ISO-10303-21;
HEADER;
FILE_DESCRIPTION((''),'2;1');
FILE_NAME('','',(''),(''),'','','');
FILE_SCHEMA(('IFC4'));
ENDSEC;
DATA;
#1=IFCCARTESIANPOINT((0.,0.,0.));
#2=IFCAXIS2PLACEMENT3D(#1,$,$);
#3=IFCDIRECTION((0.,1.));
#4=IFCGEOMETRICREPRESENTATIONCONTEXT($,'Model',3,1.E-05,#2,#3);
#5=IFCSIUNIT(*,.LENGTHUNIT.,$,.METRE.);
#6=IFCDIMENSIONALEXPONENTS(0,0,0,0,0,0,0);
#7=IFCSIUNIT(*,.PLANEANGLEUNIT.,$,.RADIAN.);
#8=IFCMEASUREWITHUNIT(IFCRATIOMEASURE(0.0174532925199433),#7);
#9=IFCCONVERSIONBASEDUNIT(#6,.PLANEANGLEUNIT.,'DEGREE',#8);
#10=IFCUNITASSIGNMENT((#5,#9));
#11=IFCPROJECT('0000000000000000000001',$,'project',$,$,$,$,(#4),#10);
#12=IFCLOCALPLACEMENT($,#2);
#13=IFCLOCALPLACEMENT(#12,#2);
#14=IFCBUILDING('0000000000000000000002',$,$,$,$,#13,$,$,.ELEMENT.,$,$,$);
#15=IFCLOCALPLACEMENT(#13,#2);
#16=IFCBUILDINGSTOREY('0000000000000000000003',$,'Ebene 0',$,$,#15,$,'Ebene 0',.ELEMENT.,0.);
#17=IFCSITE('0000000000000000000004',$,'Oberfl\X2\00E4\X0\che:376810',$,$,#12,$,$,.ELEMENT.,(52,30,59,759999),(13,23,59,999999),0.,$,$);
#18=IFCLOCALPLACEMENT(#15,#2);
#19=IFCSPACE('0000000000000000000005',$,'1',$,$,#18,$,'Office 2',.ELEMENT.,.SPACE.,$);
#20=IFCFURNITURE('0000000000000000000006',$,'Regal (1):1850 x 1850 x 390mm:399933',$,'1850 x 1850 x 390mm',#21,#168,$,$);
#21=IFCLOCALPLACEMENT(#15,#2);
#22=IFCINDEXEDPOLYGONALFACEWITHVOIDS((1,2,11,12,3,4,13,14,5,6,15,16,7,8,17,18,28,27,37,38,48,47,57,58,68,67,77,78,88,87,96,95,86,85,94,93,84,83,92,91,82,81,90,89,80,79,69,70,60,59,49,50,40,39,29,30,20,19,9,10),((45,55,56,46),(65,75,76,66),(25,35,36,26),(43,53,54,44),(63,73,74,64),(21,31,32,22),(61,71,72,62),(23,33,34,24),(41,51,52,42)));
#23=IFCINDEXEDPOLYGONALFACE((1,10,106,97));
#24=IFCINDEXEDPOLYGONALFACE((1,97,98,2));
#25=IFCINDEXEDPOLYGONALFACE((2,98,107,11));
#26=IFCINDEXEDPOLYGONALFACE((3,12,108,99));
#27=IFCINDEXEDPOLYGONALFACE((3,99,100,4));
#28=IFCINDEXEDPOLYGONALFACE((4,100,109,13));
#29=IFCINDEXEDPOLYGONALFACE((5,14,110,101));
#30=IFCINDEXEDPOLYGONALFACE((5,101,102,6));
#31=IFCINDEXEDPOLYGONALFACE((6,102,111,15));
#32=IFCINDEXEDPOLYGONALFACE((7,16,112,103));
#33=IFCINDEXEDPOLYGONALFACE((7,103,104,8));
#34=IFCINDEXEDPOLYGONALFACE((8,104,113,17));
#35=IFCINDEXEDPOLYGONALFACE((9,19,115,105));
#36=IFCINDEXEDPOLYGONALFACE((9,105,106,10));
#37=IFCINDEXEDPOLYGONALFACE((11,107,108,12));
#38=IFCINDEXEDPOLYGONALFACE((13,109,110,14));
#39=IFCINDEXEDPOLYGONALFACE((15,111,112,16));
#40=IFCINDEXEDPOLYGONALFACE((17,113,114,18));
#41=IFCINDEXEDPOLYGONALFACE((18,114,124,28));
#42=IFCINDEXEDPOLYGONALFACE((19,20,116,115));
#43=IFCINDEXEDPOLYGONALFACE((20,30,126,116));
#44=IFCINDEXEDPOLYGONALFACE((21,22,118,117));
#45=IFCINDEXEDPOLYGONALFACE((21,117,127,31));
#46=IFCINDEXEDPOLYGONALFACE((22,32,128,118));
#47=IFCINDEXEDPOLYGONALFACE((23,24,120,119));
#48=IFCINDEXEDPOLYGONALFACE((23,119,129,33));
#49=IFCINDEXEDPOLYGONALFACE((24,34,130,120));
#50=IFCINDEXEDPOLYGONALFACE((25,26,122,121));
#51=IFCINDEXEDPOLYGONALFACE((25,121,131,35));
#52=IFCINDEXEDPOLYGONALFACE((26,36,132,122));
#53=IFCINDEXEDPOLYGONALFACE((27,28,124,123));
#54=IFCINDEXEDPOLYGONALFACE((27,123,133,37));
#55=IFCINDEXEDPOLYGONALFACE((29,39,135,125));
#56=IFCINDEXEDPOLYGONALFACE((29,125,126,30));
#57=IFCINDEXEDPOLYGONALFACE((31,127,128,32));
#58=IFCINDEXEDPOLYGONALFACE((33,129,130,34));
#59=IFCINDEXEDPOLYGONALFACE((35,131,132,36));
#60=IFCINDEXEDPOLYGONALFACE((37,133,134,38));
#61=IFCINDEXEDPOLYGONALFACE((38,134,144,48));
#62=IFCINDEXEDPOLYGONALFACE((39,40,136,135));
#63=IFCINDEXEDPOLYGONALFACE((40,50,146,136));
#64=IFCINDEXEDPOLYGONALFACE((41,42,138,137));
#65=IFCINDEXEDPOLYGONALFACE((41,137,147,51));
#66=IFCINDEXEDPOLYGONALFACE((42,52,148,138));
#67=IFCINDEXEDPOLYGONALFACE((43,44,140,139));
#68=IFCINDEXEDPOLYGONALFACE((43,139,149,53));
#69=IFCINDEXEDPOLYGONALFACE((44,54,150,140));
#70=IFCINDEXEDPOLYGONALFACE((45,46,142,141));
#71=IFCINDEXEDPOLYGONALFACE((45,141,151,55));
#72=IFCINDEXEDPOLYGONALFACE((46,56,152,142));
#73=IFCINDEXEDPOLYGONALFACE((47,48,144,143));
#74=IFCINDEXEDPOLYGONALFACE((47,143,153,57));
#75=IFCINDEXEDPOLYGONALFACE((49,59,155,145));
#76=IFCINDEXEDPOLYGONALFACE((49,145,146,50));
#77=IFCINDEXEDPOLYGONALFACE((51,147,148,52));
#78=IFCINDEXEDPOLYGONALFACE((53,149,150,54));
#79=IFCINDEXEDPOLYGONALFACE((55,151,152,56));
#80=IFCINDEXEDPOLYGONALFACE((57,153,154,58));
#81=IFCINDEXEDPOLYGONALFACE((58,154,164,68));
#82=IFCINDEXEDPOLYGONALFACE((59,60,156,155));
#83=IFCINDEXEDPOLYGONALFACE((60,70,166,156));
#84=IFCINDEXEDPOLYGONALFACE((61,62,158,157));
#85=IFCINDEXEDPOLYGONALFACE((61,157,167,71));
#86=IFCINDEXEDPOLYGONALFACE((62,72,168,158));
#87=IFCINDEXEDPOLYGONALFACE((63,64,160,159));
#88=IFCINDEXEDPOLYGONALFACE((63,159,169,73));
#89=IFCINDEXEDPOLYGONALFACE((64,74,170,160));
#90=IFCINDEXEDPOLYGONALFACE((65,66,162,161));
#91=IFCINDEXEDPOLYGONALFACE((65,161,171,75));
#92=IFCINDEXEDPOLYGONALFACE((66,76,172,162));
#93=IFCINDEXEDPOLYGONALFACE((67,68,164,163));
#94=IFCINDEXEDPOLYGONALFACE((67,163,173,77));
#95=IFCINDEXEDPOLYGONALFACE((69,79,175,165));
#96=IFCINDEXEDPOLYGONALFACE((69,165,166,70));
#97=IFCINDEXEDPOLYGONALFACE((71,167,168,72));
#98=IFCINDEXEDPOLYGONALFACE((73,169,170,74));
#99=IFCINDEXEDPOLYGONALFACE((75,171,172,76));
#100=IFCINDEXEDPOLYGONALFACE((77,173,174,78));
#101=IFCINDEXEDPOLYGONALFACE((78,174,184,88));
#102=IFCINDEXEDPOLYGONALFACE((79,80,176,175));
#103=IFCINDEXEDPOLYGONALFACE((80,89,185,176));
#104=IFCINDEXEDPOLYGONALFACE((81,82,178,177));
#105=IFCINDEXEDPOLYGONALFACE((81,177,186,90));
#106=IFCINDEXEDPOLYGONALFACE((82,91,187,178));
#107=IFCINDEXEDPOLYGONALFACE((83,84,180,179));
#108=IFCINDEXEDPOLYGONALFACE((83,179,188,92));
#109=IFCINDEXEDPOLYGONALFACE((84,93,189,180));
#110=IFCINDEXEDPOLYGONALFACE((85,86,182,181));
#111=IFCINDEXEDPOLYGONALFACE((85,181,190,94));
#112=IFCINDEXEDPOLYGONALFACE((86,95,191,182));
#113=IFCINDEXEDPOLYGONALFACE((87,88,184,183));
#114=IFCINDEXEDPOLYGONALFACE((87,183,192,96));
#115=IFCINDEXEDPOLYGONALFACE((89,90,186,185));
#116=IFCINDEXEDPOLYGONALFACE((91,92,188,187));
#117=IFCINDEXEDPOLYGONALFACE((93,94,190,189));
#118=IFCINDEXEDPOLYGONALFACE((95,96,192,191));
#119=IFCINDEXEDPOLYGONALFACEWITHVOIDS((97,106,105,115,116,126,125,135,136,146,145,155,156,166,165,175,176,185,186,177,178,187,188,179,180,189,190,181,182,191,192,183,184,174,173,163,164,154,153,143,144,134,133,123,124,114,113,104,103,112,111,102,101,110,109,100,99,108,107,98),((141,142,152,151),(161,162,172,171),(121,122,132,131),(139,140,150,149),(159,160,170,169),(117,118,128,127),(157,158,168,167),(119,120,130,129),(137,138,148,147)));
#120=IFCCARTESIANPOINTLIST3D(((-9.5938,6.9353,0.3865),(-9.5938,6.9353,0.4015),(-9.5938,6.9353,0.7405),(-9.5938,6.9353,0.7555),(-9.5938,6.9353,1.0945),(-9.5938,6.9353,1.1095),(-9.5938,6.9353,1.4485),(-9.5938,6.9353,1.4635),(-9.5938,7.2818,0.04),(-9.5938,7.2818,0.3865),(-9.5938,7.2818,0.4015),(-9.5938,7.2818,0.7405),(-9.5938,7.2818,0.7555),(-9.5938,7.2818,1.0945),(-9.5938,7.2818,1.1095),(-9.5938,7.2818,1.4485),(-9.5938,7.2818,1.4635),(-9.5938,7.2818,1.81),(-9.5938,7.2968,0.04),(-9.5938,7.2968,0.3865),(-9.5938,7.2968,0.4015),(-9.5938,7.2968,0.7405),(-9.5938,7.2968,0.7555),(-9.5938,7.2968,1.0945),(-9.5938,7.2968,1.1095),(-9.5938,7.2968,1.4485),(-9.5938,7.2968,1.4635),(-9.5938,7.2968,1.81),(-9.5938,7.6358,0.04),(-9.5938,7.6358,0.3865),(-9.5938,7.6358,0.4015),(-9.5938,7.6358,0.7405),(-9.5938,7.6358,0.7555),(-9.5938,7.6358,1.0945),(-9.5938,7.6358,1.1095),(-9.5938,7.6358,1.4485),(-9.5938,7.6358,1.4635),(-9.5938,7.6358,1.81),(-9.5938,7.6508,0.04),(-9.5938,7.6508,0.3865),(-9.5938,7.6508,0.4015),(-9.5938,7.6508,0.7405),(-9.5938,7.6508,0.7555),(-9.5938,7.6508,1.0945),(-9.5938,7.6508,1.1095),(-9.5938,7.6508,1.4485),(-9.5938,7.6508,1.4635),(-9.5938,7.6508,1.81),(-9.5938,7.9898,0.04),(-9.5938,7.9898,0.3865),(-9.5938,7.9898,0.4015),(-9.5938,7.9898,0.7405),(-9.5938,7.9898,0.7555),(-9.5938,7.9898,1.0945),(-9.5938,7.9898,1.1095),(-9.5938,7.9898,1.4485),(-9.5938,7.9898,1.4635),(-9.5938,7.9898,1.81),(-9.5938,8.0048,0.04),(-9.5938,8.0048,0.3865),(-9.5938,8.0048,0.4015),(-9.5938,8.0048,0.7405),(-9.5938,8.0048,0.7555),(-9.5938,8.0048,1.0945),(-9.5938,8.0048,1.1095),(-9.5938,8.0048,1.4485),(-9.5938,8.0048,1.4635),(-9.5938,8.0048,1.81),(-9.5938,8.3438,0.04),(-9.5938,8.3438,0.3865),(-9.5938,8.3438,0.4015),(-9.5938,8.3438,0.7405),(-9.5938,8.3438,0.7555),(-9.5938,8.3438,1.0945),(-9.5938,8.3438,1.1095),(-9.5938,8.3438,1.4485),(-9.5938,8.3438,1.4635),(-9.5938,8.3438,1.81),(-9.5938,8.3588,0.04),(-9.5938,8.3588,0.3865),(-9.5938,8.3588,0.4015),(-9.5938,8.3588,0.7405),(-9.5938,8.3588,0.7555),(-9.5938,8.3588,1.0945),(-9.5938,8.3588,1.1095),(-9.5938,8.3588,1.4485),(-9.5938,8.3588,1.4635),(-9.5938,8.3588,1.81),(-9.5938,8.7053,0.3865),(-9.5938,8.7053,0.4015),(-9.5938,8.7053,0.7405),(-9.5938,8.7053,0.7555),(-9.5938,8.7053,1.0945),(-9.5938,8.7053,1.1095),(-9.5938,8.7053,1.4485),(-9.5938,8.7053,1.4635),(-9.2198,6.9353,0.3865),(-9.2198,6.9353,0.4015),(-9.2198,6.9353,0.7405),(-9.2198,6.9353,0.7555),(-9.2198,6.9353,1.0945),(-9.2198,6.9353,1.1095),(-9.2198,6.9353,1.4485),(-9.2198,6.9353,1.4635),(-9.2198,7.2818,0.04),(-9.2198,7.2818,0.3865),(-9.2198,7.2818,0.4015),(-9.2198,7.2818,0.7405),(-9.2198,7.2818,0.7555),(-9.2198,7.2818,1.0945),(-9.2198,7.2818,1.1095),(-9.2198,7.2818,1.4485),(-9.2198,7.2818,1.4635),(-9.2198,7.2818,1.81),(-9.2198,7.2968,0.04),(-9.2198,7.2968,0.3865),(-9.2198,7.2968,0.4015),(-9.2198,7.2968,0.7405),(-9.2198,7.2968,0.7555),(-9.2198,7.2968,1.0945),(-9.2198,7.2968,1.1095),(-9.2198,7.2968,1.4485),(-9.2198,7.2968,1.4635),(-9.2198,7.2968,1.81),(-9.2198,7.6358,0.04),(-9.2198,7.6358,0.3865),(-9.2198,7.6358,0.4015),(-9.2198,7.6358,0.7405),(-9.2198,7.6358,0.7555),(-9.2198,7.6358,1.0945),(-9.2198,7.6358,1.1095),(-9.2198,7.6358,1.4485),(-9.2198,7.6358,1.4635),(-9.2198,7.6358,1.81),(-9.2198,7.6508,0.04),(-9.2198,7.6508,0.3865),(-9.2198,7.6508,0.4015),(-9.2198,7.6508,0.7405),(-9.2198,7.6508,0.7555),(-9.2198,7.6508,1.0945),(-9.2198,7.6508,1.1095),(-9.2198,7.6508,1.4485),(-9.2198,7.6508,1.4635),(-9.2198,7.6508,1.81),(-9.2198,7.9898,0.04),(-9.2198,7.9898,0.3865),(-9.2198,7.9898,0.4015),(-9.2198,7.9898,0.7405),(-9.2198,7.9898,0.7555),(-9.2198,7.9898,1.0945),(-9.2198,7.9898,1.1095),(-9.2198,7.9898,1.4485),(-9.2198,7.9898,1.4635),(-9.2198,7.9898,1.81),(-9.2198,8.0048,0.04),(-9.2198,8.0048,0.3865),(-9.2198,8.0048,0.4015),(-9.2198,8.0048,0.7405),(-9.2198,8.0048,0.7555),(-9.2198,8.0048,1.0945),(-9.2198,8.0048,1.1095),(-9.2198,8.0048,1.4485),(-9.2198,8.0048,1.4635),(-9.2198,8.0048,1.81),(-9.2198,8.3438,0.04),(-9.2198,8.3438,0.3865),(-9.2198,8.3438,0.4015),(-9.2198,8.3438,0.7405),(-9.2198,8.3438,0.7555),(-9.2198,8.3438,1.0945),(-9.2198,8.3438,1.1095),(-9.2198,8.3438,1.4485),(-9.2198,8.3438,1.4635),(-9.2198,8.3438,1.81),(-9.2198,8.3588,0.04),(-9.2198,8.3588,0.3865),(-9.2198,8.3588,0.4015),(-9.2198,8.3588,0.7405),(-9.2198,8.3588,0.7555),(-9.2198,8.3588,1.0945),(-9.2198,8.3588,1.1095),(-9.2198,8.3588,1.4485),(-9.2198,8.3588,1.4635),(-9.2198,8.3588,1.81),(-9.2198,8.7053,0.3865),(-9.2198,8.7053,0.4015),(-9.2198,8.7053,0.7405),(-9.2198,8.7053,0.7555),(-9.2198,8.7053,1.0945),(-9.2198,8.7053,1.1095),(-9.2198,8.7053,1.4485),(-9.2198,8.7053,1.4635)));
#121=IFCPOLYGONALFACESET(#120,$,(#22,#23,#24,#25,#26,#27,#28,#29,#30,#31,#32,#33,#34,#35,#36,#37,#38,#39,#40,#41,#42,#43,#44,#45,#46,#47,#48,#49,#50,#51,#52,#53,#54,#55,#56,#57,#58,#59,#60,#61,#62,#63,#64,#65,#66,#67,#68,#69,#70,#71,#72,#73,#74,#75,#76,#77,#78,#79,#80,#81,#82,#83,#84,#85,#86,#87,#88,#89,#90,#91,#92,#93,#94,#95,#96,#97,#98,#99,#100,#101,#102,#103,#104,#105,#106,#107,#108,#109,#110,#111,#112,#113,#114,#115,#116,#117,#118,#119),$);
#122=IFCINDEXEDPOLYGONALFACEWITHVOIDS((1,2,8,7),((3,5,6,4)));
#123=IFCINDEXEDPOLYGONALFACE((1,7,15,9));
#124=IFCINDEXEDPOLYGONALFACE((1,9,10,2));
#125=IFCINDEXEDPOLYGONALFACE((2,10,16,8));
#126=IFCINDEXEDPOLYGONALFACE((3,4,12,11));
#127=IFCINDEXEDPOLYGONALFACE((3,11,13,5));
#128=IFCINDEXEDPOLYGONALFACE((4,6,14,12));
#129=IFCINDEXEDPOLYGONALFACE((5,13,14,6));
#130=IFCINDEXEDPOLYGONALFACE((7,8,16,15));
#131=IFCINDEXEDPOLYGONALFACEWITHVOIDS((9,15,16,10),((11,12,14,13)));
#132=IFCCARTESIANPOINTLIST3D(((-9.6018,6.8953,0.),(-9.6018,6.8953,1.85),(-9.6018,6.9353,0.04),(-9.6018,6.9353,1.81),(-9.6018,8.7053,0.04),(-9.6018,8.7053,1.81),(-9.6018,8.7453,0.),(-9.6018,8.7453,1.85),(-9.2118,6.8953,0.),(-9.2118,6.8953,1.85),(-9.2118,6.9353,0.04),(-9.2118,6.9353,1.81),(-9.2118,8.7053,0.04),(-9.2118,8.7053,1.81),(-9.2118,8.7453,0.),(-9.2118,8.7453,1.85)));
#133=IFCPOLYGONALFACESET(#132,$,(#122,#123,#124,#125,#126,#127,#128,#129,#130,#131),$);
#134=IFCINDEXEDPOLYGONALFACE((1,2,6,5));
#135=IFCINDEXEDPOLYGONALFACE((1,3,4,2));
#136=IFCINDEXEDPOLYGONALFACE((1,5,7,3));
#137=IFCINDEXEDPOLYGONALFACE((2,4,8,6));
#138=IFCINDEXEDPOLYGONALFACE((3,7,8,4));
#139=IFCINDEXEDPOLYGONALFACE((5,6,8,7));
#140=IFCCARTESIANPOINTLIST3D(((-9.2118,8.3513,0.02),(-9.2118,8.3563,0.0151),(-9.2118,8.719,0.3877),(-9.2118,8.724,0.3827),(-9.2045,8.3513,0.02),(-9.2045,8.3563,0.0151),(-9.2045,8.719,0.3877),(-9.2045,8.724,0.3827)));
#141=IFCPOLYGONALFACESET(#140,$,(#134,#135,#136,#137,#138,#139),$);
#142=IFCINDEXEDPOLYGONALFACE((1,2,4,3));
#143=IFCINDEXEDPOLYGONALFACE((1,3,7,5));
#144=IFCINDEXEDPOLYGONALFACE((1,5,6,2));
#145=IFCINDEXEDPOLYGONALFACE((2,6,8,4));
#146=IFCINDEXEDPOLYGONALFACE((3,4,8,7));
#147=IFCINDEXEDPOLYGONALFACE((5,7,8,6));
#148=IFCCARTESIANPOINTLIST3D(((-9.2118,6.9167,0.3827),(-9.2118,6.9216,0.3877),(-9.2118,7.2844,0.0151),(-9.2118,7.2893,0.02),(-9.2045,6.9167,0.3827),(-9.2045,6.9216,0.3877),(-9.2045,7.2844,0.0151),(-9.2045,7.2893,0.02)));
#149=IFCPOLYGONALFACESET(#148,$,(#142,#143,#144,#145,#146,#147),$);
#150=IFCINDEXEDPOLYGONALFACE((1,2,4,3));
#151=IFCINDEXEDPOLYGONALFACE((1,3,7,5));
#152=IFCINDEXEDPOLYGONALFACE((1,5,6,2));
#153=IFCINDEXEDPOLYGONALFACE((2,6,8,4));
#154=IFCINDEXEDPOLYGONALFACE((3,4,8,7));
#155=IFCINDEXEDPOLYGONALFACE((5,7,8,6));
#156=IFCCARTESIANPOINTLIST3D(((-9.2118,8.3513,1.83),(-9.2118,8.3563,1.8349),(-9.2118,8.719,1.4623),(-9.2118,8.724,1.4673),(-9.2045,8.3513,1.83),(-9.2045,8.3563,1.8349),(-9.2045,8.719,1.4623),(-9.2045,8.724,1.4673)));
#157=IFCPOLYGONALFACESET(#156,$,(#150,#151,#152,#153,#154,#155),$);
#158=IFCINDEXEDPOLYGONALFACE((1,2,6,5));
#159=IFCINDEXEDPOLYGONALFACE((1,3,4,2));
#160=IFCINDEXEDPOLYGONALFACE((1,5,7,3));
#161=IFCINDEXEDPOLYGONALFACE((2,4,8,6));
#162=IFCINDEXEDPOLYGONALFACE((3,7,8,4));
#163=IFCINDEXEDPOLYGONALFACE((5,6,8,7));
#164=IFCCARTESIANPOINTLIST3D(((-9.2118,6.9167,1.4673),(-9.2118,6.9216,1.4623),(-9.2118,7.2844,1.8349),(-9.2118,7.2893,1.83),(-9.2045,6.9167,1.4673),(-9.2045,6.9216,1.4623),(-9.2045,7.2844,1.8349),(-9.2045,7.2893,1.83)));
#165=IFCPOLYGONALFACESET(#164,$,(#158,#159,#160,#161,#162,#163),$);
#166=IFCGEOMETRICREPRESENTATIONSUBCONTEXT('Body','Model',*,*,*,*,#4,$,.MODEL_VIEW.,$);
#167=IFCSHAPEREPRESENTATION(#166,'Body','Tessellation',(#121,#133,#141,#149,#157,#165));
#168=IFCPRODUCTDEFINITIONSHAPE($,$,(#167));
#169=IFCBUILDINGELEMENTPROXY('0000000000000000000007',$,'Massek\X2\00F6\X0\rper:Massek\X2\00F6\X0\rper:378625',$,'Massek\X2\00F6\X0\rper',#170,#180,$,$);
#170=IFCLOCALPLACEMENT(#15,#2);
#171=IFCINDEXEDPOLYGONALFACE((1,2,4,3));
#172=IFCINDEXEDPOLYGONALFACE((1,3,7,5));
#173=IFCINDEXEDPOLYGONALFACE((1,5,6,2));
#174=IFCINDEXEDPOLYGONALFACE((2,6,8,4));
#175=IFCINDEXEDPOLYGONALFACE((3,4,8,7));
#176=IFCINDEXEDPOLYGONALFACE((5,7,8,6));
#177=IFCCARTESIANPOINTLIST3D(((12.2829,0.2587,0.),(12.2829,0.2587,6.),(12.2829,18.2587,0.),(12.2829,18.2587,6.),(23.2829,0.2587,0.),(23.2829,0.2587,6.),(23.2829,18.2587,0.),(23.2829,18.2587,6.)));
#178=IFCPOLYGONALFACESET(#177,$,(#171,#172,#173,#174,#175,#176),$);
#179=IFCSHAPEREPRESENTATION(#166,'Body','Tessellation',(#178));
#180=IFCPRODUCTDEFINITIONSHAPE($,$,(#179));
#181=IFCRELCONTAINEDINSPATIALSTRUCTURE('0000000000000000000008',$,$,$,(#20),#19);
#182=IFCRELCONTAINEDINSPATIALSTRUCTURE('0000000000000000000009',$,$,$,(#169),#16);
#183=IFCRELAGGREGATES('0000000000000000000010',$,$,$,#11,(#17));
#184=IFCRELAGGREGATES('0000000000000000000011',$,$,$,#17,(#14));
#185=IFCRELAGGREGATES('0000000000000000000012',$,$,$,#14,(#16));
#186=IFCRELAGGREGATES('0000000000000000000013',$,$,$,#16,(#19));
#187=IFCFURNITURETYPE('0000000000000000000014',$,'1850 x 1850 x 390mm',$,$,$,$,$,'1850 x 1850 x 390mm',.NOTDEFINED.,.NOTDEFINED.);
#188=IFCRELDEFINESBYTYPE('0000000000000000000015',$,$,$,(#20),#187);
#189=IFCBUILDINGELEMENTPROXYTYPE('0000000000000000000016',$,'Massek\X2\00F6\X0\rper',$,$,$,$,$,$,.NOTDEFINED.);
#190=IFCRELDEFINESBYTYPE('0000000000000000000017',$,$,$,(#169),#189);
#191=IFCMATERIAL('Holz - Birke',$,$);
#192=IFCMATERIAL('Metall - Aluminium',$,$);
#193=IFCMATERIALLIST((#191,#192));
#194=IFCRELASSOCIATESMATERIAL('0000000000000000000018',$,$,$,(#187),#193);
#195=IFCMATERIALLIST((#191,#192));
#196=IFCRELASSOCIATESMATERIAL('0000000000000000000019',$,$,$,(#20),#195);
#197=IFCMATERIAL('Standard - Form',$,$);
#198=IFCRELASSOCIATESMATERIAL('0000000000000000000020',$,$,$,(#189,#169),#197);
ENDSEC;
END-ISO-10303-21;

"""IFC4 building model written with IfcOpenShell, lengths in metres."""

from ifc_helpers import new_model, entity, si_unit, converted_unit, direction, frame, frame_2d, origin, place, context, subcontext, project, spatial, polyline, rectangle, outline, extrude, source, transform, mapped, material, material_list, type_object, type_shapes, element, save


model = new_model("IFC4")

# Units and contexts
model_context = context("Model", 3, precision=1e-05, world=origin(), true_north=direction((0.0, 1.0)))
body_context = subcontext(model_context, "Body", "Model", "MODEL_VIEW")
ifc_project = project(units=[si_unit("LENGTHUNIT", "METRE"), converted_unit("PLANEANGLEUNIT", "DEGREE", entity("IfcRatioMeasure", 0.0174532925199433), si_unit("PLANEANGLEUNIT", "RADIAN"), dimensions=[0, 0, 0, 0, 0, 0, 0])], contexts=[model_context])

# Site, building, storey
site_placement = place(None, origin())
site = spatial("IfcSite", under=ifc_project, at=site_placement, Name="Oberfläche:376810", CompositionType="ELEMENT", RefLatitude=(52, 30, 59, 759999), RefLongitude=(13, 23, 59, 999999), RefElevation=0.0)
building_placement = place(site_placement, origin())
building = spatial("IfcBuilding", under=site, at=building_placement, CompositionType="ELEMENT")
storey_placement = place(building_placement, origin())
storey = spatial("IfcBuildingStorey", under=building, at=storey_placement, Name="Ebene 0", LongName="Ebene 0", CompositionType="ELEMENT", Elevation=0.0)

# Shared definitions
space_placement = place(storey_placement, origin())
space = spatial("IfcSpace", under=storey, at=space_placement, Name="1", LongName="Office 2", CompositionType="ELEMENT", PredefinedType="SPACE")

# Furniture
ifc_material_1 = material(Name="Holz - Birke")
ifc_material_2 = material(Name="Metall - Aluminium")
ifc_material_list_1 = material_list([ifc_material_1, ifc_material_2])
furniture_type_1 = type_object("IfcFurnitureType", Name="1850 x 1850 x 390mm", ElementType="1850 x 1850 x 390mm", AssemblyPlace="NOTDEFINED", PredefinedType="NOTDEFINED", material=ifc_material_list_1)
shared_shape_1 = source(origin(), body_context, "Body", "SweptSolid", [
    extrude(outline(polyline([(0.5385, -0.5385), (0.885, -0.5385), (0.885, -0.5235), (0.5385, -0.5235), (0.5385, -0.1845), (0.885, -0.1845), (0.885, -0.1695), (0.5385, -0.1695), (0.5385, 0.1695), (0.885, 0.1695), (0.885, 0.1845), (0.5385, 0.1845), (0.5385, 0.5235), (0.885, 0.5235), (0.885, 0.5385), (0.5385, 0.5385), (0.5385, 0.885), (0.5235, 0.885), (0.5235, 0.5385), (0.1845, 0.5385), (0.1845, 0.885), (0.1695, 0.885), (0.1695, 0.5385), (-0.1695, 0.5385), (-0.1695, 0.885), (-0.1845, 0.885), (-0.1845, 0.5385), (-0.5235, 0.5385), (-0.5235, 0.885), (-0.5385, 0.885), (-0.5385, 0.5385), (-0.885, 0.5385), (-0.885, 0.5235), (-0.5385, 0.5235), (-0.5385, 0.1845), (-0.885, 0.1845), (-0.885, 0.1695), (-0.5385, 0.1695), (-0.5385, -0.1695), (-0.885, -0.1695), (-0.885, -0.1845), (-0.5385, -0.1845), (-0.5385, -0.5235), (-0.885, -0.5235), (-0.885, -0.5385), (-0.5385, -0.5385), (-0.5385, -0.885), (-0.5235, -0.885), (-0.5235, -0.5385), (-0.1845, -0.5385), (-0.1845, -0.885), (-0.1695, -0.885), (-0.1695, -0.5385), (0.1695, -0.5385), (0.1695, -0.885), (0.1845, -0.885), (0.1845, -0.5385), (0.5235, -0.5385), (0.5235, -0.885), (0.5385, -0.885), (0.5385, -0.5385)]), holes=[polyline([(0.5235, -0.1845), (0.5235, -0.5235), (0.1845, -0.5235), (0.1845, -0.1845), (0.5235, -0.1845)]), polyline([(0.1845, -0.1695), (0.1845, 0.1695), (0.5235, 0.1695), (0.5235, -0.1695), (0.1845, -0.1695)]), polyline([(0.1845, 0.1845), (0.1845, 0.5235), (0.5235, 0.5235), (0.5235, 0.1845), (0.1845, 0.1845)]), polyline([(-0.1695, 0.5235), (0.1695, 0.5235), (0.1695, 0.1845), (-0.1695, 0.1845), (-0.1695, 0.5235)]), polyline([(-0.1695, 0.1695), (0.1695, 0.1695), (0.1695, -0.1695), (-0.1695, -0.1695), (-0.1695, 0.1695)]), polyline([(-0.1695, -0.1845), (0.1695, -0.1845), (0.1695, -0.5235), (-0.1695, -0.5235), (-0.1695, -0.1845)]), polyline([(-0.5235, -0.5235), (-0.5235, -0.1845), (-0.1845, -0.1845), (-0.1845, -0.5235), (-0.5235, -0.5235)]), polyline([(-0.5235, -0.1695), (-0.5235, 0.1695), (-0.1845, 0.1695), (-0.1845, -0.1695), (-0.5235, -0.1695)]), polyline([(-0.5235, 0.1845), (-0.5235, 0.5235), (-0.1845, 0.5235), (-0.1845, 0.1845), (-0.5235, 0.1845)])]), frame((0.2471, -0.2571, 0.925), z_axis=(0.0, 1.0, 0.0), x_axis=(0.0, 0.0, 1.0)), (0.0, 0.0, 1.0), 0.374),
    extrude(outline(polyline([(-0.925, -0.925), (0.925, -0.925), (0.925, 0.925), (-0.925, 0.925), (-0.925, -0.925)]), holes=[polyline([(-0.885, -0.885), (-0.885, 0.885), (0.885, 0.885), (0.885, -0.885), (-0.885, -0.885)])]), frame((0.2471, -0.2651, 0.925), z_axis=(0.0, 1.0, 0.0), x_axis=(0.0, 0.0, -1.0)), (0.0, 0.0, 1.0), 0.39),
    extrude(rectangle(XDim=0.007, YDim=0.0073, at=frame_2d((0.0, 0.0), x_axis=(0.0, 1.0))), frame((-0.2864, 0.1286, 0.0175), z_axis=(-0.707107, 0.0, 0.707107), x_axis=(0.0, 1.0, 0.0)), (0.0, 0.0, 1.0), 0.52),
    extrude(rectangle(XDim=0.007, YDim=0.0073, at=frame_2d((0.0, 0.0), x_axis=(0.0, 1.0))), frame((0.7805, 0.1286, 0.0175), z_axis=(0.707107, 0.0, 0.707107), x_axis=(0.0, 1.0, 0.0)), (0.0, 0.0, 1.0), 0.52),
    extrude(rectangle(XDim=0.007, YDim=0.0073, at=frame_2d((0.0, 0.0), x_axis=(0.0, 1.0))), frame((-0.6541, 0.1286, 1.4648), z_axis=(0.707107, 0.0, 0.707107), x_axis=(0.0, 1.0, 0.0)), (0.0, 0.0, 1.0), 0.52),
    extrude(rectangle(XDim=0.007, YDim=0.0073, at=frame_2d((0.0, 0.0), x_axis=(0.0, 1.0))), frame((1.1482, 0.1286, 1.4648), z_axis=(-0.707107, 0.0, 0.707107), x_axis=(0.0, 1.0, 0.0)), (0.0, 0.0, 1.0), 0.52),
])
type_shapes(furniture_type_1, [shared_shape_1])
ifc_material_list_2 = material_list([ifc_material_1, ifc_material_2])
furniture_1_placement = place(space_placement, frame((-9.3367, 8.0674, 0.0), z_axis=(0.0, 0.0, 1.0), x_axis=(0.0, -1.0, 0.0)))
element("IfcFurniture", 1, at=furniture_1_placement, inside=space, type_object=furniture_type_1, material=ifc_material_list_2, Name="Regal (1):1850 x 1850 x 390mm:399933", ObjectType="1850 x 1850 x 390mm", context=body_context, shape_type="MappedRepresentation", body=[
    mapped(shared_shape_1, transform((0.0, 0.0, 0.0), scale=1.0)),
])

# Building element proxy
ifc_material_3 = material(Name="Standard - Form")
building_element_proxy_type_1 = type_object("IfcBuildingElementProxyType", Name="Massekörper", PredefinedType="NOTDEFINED", material=ifc_material_3)
shared_shape_2 = source(origin(), body_context, "Body", "SweptSolid", [
    extrude(rectangle(XDim=18.0, YDim=11.0, at=frame_2d((0.0, 0.0), x_axis=(1.0, 0.0))), frame((5.5, 9.0, 0.0), z_axis=(0.0, 0.0, 1.0), x_axis=(0.0, 1.0, 0.0)), (0.0, 0.0, 1.0), 6.0),
])
type_shapes(building_element_proxy_type_1, [shared_shape_2])
proxy_1_placement = place(storey_placement, frame((12.2829, 0.2587, 0.0)))
element("IfcBuildingElementProxy", 2, at=proxy_1_placement, inside=storey, type_object=building_element_proxy_type_1, material=ifc_material_3, Name="Massekörper:Massekörper:378625", ObjectType="Massekörper", context=body_context, shape_type="MappedRepresentation", body=[
    mapped(shared_shape_2, transform((0.0, 0.0, 0.0), scale=1.0)),
])

save(model, "model.ifc")
